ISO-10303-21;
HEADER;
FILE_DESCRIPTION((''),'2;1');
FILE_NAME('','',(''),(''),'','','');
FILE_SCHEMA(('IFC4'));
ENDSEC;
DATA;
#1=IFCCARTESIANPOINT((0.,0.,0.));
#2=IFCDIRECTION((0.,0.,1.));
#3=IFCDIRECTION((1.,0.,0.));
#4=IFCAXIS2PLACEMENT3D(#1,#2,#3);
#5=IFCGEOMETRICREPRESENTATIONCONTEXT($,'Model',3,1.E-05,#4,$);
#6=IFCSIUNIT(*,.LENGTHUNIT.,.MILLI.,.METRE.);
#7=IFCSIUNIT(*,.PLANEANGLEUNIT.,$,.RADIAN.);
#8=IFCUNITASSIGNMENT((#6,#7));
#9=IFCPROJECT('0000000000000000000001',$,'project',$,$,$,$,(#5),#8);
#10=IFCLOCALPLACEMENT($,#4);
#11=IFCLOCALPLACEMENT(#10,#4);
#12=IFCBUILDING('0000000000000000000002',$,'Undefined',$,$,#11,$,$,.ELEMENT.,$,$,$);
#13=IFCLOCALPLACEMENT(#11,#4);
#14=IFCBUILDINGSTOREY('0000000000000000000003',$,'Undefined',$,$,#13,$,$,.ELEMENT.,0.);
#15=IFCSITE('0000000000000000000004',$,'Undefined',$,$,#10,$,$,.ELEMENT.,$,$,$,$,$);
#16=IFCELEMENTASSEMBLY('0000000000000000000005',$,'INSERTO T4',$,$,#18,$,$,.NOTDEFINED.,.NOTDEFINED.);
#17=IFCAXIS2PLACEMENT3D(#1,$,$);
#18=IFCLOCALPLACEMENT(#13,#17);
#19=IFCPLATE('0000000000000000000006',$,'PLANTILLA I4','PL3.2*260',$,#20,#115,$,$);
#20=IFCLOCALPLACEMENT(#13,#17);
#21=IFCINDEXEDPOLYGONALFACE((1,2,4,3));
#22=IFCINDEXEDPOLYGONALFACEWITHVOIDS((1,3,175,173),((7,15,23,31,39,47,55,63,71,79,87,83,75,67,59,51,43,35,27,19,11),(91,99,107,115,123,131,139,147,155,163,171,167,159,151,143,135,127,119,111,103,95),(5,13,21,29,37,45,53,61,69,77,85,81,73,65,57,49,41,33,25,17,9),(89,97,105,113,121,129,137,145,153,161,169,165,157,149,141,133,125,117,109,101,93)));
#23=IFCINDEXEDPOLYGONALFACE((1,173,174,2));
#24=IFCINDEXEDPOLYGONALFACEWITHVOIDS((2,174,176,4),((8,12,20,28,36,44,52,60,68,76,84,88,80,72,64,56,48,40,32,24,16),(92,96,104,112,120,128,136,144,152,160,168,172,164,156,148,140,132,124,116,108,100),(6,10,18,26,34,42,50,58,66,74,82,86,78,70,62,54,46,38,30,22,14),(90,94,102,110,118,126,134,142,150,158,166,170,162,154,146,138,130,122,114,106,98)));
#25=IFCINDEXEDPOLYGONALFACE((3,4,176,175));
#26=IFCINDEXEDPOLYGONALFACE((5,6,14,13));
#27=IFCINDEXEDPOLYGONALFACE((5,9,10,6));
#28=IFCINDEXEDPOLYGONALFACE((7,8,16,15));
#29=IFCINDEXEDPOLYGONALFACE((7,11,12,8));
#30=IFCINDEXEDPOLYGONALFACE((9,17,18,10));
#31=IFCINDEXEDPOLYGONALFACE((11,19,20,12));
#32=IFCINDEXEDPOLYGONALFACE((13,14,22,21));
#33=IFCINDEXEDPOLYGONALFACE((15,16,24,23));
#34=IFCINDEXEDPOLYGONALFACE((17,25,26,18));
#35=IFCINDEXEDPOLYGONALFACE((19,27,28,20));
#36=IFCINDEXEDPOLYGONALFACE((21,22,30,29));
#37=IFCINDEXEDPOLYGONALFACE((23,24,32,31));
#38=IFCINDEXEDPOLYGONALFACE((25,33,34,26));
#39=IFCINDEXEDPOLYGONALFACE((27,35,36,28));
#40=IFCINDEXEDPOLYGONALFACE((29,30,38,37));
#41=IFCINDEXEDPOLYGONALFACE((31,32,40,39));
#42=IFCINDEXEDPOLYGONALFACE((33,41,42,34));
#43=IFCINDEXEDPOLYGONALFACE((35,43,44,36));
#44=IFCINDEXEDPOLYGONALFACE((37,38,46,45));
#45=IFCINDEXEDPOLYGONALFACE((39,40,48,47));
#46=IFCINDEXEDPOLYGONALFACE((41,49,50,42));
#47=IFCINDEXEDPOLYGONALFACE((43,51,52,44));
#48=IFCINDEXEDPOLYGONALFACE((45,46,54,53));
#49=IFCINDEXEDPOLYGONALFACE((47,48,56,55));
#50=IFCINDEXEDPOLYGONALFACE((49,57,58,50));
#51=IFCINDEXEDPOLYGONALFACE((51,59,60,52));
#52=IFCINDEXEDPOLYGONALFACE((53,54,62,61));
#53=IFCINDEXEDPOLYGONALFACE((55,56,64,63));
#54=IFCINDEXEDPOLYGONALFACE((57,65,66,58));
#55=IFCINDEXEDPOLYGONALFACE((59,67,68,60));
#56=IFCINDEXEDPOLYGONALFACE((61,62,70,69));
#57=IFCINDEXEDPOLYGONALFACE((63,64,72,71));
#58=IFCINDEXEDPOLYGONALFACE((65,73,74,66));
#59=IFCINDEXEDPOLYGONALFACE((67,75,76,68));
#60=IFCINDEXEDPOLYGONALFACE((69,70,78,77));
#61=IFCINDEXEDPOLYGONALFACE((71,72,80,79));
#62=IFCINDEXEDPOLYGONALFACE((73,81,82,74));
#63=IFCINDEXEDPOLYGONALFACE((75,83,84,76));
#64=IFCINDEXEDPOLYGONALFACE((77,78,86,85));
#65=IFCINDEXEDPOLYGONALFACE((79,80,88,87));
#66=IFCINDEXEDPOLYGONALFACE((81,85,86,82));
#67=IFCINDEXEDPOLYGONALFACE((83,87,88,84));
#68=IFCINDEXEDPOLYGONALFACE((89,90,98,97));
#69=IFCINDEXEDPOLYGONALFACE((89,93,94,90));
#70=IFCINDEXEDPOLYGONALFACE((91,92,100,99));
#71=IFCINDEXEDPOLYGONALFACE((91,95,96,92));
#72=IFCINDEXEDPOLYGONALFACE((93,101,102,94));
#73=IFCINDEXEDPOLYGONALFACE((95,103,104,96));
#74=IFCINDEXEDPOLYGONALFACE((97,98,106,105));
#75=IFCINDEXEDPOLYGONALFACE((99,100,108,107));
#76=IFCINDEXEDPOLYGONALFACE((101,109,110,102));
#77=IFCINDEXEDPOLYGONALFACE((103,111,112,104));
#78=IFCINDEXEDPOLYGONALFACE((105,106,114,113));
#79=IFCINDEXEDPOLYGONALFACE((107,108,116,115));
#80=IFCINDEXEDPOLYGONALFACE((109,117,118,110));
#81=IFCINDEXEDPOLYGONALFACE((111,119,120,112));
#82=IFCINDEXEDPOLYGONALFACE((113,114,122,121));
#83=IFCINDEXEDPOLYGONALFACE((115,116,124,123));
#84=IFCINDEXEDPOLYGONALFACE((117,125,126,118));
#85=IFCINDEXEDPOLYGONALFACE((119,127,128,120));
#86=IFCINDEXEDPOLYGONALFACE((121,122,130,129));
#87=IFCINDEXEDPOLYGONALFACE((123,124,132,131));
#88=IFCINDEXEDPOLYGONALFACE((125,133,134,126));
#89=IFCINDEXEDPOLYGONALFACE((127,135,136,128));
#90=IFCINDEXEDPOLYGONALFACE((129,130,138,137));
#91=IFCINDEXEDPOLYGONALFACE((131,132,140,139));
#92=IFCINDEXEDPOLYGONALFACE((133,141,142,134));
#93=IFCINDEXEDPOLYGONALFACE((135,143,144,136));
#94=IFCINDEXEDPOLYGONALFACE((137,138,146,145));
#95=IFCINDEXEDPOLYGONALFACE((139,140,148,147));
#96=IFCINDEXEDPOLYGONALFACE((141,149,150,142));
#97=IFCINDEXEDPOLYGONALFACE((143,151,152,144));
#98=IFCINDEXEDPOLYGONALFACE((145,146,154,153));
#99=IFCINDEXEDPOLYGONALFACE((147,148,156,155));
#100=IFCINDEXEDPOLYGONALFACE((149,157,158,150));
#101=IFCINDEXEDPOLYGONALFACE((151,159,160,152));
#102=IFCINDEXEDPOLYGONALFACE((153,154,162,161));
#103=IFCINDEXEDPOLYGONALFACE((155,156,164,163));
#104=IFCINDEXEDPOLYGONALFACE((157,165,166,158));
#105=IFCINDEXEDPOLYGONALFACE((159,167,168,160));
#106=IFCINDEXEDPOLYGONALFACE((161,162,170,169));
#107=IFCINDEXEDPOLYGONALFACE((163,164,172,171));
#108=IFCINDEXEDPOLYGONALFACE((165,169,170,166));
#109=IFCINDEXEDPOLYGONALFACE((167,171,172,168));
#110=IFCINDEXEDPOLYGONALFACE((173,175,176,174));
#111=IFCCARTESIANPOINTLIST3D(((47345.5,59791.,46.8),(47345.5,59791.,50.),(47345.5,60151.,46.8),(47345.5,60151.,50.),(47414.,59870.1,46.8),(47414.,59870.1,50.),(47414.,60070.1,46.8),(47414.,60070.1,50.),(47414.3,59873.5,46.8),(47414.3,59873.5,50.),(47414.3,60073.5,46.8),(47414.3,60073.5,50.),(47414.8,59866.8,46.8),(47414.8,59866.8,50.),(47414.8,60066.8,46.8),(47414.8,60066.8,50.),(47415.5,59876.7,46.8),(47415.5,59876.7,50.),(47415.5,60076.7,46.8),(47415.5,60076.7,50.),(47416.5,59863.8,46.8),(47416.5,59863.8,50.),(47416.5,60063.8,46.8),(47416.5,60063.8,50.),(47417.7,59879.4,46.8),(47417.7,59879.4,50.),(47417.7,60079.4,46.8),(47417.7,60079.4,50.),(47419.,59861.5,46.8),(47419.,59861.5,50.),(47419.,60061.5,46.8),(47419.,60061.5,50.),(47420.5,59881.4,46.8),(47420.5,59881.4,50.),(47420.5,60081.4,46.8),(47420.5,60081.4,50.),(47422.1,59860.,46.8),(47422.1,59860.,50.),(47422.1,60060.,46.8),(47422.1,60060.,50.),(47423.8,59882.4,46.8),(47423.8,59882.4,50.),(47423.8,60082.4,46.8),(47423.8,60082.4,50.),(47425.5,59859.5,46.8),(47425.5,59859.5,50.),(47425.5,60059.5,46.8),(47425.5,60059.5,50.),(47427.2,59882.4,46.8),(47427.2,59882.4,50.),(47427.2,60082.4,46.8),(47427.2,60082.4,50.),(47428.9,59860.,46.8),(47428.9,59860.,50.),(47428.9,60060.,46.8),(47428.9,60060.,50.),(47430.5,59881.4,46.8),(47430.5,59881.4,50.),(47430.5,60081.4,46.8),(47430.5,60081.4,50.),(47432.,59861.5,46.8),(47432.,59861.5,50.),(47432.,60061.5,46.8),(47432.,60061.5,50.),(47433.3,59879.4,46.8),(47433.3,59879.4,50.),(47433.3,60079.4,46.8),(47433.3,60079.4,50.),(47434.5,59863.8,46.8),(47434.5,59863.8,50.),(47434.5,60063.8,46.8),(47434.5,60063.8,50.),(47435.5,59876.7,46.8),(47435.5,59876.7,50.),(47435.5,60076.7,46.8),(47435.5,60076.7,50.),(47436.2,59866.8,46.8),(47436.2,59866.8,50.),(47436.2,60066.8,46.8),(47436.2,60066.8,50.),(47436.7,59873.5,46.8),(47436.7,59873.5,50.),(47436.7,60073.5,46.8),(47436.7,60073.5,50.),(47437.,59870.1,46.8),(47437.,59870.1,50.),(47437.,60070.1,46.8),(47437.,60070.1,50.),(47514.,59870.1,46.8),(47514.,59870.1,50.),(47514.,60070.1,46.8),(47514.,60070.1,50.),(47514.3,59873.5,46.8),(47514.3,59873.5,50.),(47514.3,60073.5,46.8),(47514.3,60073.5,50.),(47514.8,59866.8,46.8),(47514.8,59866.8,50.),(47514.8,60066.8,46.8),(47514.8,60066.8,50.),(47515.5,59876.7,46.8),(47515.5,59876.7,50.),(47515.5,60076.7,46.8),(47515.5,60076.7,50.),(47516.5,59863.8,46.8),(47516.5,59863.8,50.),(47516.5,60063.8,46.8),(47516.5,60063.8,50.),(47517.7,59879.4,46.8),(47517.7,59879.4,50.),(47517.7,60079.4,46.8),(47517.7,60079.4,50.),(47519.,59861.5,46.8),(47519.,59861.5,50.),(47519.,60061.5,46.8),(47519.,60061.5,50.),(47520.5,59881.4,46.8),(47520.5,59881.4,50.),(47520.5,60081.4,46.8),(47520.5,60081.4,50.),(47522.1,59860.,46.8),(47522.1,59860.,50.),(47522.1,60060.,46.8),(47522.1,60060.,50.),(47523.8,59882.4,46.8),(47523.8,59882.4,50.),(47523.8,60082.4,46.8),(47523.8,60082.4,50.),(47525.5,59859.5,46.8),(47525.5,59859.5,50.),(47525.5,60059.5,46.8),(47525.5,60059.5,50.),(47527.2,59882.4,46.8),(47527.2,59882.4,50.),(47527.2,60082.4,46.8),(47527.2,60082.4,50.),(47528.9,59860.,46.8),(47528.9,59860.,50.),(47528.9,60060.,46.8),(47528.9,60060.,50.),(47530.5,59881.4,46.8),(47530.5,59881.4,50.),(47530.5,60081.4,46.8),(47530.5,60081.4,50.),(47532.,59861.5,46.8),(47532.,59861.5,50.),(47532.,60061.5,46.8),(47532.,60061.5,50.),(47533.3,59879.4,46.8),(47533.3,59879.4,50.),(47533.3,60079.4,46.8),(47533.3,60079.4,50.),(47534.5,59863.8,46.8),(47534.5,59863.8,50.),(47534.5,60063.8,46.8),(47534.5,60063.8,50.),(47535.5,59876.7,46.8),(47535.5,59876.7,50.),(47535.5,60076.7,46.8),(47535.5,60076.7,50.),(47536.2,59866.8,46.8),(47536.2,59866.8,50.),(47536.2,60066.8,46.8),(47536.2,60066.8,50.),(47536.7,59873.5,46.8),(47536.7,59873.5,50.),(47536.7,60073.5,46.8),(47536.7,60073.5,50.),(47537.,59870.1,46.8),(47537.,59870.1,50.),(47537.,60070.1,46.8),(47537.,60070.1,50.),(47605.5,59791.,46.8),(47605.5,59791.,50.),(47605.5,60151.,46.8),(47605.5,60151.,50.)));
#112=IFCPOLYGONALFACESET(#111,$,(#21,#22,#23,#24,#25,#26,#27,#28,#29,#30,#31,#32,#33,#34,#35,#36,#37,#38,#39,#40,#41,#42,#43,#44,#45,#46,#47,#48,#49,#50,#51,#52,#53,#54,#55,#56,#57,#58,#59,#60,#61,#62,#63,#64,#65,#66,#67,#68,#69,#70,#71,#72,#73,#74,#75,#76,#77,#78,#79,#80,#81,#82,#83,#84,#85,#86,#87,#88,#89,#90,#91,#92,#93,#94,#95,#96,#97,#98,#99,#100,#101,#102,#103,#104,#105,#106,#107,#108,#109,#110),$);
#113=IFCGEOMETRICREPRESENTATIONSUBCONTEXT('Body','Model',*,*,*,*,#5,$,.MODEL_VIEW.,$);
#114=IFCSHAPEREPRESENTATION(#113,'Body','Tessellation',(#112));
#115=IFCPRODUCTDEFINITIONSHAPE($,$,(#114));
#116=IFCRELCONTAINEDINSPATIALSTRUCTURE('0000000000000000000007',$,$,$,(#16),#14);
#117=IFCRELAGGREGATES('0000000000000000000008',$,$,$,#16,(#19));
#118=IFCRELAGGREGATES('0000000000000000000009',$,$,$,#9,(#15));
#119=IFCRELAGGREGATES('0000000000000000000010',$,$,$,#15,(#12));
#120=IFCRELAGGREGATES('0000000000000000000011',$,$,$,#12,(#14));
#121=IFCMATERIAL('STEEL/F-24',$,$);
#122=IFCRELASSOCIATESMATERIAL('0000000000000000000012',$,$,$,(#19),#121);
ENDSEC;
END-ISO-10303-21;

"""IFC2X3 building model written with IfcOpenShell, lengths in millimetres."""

from ifc_helpers import new_model, si_unit, frame, origin_with_axes, origin_2d_with_axis, place, context, subcontext, project, spatial, polyline, circle, outline, extrude, source, transform, mapped, material, element, aggregate, save


model = new_model("IFC2X3")

# Units and contexts
model_context = context("Model", 3, precision=1e-05, world=origin_with_axes())
body_context = subcontext(model_context, "Body", "Model", "MODEL_VIEW")
ifc_project = project(units=[si_unit("LENGTHUNIT", "METRE", prefix="MILLI"), si_unit("PLANEANGLEUNIT", "RADIAN")], contexts=[model_context])

# Site, building, storey
site_placement = place(None, origin_with_axes())
site = spatial("IfcSite", under=ifc_project, at=site_placement, Name="Undefined", CompositionType="ELEMENT")
building_placement = place(site_placement, origin_with_axes())
building = spatial("IfcBuilding", under=site, at=building_placement, Name="Undefined", CompositionType="ELEMENT")
storey_placement = place(building_placement, origin_with_axes())
storey = spatial("IfcBuildingStorey", under=building, at=storey_placement, Name="Undefined", CompositionType="ELEMENT", Elevation=0.0)

# Element assembly
assembly_1_placement = place(storey_placement, origin_with_axes())
assembly_1 = element("IfcElementAssembly", 1, at=assembly_1_placement, inside=storey, Name="INSERTO T4", AssemblyPlace="NOTDEFINED", PredefinedType="NOTDEFINED")

# Plate, opening
ifc_material_1 = material(Name="STEEL/F-24")
plate_1_placement = place(assembly_1_placement, frame((47345.5, 59791.0, 48.4), z_axis=(0.0, 0.0, -1.0), x_axis=(0.0, 1.0, 0.0)))
plate_1 = element("IfcPlate", 2, at=plate_1_placement, material=ifc_material_1, Name="PLANTILLA I4", Description="PL3.2*260", context=body_context, shape_type="SweptSolid", body=[
    extrude(outline(polyline([(0.0, 0.0), (360.0, 0.0), (360.0, 260.0), (0.0, 260.0), (0.0, 0.0)])), frame((0.0, 0.0, -1.6), z_axis=(0.0, 0.0, 1.0), x_axis=(1.0, 0.0, 0.0)), (0.0, 0.0, 1.0), 3.2),
])
shared_shape_1 = source(origin_with_axes(), body_context, "Body", "SweptSolid", [
    extrude(circle(Radius=11.5, at=origin_2d_with_axis()), frame((0.0, -0.1, 0.0), z_axis=(0.0, 1.0, 0.0), x_axis=(1.0, 0.0, 0.0)), (0.0, 0.0, 1.0), 3.4),
])
opening_1_placement = place(assembly_1_placement, frame((47475.5, 60071.0, 50.0), z_axis=(1.0, 0.0, 0.0), x_axis=(0.0, -1.0, 0.0)))
element("IfcOpeningElement", 3, at=opening_1_placement, cuts=plate_1, ObjectType="Opening", context=body_context, shape_type="MappedRepresentation", body=[
    mapped(shared_shape_1, transform((0.0, 0.0, 50.0))),
    mapped(shared_shape_1, transform((200.0, 0.0, 50.0))),
    mapped(shared_shape_1, transform((0.0, 0.0, -50.0))),
    mapped(shared_shape_1, transform((200.0, 0.0, -50.0))),
])
aggregate(assembly_1, [plate_1])

save(model, "model.ifc")
